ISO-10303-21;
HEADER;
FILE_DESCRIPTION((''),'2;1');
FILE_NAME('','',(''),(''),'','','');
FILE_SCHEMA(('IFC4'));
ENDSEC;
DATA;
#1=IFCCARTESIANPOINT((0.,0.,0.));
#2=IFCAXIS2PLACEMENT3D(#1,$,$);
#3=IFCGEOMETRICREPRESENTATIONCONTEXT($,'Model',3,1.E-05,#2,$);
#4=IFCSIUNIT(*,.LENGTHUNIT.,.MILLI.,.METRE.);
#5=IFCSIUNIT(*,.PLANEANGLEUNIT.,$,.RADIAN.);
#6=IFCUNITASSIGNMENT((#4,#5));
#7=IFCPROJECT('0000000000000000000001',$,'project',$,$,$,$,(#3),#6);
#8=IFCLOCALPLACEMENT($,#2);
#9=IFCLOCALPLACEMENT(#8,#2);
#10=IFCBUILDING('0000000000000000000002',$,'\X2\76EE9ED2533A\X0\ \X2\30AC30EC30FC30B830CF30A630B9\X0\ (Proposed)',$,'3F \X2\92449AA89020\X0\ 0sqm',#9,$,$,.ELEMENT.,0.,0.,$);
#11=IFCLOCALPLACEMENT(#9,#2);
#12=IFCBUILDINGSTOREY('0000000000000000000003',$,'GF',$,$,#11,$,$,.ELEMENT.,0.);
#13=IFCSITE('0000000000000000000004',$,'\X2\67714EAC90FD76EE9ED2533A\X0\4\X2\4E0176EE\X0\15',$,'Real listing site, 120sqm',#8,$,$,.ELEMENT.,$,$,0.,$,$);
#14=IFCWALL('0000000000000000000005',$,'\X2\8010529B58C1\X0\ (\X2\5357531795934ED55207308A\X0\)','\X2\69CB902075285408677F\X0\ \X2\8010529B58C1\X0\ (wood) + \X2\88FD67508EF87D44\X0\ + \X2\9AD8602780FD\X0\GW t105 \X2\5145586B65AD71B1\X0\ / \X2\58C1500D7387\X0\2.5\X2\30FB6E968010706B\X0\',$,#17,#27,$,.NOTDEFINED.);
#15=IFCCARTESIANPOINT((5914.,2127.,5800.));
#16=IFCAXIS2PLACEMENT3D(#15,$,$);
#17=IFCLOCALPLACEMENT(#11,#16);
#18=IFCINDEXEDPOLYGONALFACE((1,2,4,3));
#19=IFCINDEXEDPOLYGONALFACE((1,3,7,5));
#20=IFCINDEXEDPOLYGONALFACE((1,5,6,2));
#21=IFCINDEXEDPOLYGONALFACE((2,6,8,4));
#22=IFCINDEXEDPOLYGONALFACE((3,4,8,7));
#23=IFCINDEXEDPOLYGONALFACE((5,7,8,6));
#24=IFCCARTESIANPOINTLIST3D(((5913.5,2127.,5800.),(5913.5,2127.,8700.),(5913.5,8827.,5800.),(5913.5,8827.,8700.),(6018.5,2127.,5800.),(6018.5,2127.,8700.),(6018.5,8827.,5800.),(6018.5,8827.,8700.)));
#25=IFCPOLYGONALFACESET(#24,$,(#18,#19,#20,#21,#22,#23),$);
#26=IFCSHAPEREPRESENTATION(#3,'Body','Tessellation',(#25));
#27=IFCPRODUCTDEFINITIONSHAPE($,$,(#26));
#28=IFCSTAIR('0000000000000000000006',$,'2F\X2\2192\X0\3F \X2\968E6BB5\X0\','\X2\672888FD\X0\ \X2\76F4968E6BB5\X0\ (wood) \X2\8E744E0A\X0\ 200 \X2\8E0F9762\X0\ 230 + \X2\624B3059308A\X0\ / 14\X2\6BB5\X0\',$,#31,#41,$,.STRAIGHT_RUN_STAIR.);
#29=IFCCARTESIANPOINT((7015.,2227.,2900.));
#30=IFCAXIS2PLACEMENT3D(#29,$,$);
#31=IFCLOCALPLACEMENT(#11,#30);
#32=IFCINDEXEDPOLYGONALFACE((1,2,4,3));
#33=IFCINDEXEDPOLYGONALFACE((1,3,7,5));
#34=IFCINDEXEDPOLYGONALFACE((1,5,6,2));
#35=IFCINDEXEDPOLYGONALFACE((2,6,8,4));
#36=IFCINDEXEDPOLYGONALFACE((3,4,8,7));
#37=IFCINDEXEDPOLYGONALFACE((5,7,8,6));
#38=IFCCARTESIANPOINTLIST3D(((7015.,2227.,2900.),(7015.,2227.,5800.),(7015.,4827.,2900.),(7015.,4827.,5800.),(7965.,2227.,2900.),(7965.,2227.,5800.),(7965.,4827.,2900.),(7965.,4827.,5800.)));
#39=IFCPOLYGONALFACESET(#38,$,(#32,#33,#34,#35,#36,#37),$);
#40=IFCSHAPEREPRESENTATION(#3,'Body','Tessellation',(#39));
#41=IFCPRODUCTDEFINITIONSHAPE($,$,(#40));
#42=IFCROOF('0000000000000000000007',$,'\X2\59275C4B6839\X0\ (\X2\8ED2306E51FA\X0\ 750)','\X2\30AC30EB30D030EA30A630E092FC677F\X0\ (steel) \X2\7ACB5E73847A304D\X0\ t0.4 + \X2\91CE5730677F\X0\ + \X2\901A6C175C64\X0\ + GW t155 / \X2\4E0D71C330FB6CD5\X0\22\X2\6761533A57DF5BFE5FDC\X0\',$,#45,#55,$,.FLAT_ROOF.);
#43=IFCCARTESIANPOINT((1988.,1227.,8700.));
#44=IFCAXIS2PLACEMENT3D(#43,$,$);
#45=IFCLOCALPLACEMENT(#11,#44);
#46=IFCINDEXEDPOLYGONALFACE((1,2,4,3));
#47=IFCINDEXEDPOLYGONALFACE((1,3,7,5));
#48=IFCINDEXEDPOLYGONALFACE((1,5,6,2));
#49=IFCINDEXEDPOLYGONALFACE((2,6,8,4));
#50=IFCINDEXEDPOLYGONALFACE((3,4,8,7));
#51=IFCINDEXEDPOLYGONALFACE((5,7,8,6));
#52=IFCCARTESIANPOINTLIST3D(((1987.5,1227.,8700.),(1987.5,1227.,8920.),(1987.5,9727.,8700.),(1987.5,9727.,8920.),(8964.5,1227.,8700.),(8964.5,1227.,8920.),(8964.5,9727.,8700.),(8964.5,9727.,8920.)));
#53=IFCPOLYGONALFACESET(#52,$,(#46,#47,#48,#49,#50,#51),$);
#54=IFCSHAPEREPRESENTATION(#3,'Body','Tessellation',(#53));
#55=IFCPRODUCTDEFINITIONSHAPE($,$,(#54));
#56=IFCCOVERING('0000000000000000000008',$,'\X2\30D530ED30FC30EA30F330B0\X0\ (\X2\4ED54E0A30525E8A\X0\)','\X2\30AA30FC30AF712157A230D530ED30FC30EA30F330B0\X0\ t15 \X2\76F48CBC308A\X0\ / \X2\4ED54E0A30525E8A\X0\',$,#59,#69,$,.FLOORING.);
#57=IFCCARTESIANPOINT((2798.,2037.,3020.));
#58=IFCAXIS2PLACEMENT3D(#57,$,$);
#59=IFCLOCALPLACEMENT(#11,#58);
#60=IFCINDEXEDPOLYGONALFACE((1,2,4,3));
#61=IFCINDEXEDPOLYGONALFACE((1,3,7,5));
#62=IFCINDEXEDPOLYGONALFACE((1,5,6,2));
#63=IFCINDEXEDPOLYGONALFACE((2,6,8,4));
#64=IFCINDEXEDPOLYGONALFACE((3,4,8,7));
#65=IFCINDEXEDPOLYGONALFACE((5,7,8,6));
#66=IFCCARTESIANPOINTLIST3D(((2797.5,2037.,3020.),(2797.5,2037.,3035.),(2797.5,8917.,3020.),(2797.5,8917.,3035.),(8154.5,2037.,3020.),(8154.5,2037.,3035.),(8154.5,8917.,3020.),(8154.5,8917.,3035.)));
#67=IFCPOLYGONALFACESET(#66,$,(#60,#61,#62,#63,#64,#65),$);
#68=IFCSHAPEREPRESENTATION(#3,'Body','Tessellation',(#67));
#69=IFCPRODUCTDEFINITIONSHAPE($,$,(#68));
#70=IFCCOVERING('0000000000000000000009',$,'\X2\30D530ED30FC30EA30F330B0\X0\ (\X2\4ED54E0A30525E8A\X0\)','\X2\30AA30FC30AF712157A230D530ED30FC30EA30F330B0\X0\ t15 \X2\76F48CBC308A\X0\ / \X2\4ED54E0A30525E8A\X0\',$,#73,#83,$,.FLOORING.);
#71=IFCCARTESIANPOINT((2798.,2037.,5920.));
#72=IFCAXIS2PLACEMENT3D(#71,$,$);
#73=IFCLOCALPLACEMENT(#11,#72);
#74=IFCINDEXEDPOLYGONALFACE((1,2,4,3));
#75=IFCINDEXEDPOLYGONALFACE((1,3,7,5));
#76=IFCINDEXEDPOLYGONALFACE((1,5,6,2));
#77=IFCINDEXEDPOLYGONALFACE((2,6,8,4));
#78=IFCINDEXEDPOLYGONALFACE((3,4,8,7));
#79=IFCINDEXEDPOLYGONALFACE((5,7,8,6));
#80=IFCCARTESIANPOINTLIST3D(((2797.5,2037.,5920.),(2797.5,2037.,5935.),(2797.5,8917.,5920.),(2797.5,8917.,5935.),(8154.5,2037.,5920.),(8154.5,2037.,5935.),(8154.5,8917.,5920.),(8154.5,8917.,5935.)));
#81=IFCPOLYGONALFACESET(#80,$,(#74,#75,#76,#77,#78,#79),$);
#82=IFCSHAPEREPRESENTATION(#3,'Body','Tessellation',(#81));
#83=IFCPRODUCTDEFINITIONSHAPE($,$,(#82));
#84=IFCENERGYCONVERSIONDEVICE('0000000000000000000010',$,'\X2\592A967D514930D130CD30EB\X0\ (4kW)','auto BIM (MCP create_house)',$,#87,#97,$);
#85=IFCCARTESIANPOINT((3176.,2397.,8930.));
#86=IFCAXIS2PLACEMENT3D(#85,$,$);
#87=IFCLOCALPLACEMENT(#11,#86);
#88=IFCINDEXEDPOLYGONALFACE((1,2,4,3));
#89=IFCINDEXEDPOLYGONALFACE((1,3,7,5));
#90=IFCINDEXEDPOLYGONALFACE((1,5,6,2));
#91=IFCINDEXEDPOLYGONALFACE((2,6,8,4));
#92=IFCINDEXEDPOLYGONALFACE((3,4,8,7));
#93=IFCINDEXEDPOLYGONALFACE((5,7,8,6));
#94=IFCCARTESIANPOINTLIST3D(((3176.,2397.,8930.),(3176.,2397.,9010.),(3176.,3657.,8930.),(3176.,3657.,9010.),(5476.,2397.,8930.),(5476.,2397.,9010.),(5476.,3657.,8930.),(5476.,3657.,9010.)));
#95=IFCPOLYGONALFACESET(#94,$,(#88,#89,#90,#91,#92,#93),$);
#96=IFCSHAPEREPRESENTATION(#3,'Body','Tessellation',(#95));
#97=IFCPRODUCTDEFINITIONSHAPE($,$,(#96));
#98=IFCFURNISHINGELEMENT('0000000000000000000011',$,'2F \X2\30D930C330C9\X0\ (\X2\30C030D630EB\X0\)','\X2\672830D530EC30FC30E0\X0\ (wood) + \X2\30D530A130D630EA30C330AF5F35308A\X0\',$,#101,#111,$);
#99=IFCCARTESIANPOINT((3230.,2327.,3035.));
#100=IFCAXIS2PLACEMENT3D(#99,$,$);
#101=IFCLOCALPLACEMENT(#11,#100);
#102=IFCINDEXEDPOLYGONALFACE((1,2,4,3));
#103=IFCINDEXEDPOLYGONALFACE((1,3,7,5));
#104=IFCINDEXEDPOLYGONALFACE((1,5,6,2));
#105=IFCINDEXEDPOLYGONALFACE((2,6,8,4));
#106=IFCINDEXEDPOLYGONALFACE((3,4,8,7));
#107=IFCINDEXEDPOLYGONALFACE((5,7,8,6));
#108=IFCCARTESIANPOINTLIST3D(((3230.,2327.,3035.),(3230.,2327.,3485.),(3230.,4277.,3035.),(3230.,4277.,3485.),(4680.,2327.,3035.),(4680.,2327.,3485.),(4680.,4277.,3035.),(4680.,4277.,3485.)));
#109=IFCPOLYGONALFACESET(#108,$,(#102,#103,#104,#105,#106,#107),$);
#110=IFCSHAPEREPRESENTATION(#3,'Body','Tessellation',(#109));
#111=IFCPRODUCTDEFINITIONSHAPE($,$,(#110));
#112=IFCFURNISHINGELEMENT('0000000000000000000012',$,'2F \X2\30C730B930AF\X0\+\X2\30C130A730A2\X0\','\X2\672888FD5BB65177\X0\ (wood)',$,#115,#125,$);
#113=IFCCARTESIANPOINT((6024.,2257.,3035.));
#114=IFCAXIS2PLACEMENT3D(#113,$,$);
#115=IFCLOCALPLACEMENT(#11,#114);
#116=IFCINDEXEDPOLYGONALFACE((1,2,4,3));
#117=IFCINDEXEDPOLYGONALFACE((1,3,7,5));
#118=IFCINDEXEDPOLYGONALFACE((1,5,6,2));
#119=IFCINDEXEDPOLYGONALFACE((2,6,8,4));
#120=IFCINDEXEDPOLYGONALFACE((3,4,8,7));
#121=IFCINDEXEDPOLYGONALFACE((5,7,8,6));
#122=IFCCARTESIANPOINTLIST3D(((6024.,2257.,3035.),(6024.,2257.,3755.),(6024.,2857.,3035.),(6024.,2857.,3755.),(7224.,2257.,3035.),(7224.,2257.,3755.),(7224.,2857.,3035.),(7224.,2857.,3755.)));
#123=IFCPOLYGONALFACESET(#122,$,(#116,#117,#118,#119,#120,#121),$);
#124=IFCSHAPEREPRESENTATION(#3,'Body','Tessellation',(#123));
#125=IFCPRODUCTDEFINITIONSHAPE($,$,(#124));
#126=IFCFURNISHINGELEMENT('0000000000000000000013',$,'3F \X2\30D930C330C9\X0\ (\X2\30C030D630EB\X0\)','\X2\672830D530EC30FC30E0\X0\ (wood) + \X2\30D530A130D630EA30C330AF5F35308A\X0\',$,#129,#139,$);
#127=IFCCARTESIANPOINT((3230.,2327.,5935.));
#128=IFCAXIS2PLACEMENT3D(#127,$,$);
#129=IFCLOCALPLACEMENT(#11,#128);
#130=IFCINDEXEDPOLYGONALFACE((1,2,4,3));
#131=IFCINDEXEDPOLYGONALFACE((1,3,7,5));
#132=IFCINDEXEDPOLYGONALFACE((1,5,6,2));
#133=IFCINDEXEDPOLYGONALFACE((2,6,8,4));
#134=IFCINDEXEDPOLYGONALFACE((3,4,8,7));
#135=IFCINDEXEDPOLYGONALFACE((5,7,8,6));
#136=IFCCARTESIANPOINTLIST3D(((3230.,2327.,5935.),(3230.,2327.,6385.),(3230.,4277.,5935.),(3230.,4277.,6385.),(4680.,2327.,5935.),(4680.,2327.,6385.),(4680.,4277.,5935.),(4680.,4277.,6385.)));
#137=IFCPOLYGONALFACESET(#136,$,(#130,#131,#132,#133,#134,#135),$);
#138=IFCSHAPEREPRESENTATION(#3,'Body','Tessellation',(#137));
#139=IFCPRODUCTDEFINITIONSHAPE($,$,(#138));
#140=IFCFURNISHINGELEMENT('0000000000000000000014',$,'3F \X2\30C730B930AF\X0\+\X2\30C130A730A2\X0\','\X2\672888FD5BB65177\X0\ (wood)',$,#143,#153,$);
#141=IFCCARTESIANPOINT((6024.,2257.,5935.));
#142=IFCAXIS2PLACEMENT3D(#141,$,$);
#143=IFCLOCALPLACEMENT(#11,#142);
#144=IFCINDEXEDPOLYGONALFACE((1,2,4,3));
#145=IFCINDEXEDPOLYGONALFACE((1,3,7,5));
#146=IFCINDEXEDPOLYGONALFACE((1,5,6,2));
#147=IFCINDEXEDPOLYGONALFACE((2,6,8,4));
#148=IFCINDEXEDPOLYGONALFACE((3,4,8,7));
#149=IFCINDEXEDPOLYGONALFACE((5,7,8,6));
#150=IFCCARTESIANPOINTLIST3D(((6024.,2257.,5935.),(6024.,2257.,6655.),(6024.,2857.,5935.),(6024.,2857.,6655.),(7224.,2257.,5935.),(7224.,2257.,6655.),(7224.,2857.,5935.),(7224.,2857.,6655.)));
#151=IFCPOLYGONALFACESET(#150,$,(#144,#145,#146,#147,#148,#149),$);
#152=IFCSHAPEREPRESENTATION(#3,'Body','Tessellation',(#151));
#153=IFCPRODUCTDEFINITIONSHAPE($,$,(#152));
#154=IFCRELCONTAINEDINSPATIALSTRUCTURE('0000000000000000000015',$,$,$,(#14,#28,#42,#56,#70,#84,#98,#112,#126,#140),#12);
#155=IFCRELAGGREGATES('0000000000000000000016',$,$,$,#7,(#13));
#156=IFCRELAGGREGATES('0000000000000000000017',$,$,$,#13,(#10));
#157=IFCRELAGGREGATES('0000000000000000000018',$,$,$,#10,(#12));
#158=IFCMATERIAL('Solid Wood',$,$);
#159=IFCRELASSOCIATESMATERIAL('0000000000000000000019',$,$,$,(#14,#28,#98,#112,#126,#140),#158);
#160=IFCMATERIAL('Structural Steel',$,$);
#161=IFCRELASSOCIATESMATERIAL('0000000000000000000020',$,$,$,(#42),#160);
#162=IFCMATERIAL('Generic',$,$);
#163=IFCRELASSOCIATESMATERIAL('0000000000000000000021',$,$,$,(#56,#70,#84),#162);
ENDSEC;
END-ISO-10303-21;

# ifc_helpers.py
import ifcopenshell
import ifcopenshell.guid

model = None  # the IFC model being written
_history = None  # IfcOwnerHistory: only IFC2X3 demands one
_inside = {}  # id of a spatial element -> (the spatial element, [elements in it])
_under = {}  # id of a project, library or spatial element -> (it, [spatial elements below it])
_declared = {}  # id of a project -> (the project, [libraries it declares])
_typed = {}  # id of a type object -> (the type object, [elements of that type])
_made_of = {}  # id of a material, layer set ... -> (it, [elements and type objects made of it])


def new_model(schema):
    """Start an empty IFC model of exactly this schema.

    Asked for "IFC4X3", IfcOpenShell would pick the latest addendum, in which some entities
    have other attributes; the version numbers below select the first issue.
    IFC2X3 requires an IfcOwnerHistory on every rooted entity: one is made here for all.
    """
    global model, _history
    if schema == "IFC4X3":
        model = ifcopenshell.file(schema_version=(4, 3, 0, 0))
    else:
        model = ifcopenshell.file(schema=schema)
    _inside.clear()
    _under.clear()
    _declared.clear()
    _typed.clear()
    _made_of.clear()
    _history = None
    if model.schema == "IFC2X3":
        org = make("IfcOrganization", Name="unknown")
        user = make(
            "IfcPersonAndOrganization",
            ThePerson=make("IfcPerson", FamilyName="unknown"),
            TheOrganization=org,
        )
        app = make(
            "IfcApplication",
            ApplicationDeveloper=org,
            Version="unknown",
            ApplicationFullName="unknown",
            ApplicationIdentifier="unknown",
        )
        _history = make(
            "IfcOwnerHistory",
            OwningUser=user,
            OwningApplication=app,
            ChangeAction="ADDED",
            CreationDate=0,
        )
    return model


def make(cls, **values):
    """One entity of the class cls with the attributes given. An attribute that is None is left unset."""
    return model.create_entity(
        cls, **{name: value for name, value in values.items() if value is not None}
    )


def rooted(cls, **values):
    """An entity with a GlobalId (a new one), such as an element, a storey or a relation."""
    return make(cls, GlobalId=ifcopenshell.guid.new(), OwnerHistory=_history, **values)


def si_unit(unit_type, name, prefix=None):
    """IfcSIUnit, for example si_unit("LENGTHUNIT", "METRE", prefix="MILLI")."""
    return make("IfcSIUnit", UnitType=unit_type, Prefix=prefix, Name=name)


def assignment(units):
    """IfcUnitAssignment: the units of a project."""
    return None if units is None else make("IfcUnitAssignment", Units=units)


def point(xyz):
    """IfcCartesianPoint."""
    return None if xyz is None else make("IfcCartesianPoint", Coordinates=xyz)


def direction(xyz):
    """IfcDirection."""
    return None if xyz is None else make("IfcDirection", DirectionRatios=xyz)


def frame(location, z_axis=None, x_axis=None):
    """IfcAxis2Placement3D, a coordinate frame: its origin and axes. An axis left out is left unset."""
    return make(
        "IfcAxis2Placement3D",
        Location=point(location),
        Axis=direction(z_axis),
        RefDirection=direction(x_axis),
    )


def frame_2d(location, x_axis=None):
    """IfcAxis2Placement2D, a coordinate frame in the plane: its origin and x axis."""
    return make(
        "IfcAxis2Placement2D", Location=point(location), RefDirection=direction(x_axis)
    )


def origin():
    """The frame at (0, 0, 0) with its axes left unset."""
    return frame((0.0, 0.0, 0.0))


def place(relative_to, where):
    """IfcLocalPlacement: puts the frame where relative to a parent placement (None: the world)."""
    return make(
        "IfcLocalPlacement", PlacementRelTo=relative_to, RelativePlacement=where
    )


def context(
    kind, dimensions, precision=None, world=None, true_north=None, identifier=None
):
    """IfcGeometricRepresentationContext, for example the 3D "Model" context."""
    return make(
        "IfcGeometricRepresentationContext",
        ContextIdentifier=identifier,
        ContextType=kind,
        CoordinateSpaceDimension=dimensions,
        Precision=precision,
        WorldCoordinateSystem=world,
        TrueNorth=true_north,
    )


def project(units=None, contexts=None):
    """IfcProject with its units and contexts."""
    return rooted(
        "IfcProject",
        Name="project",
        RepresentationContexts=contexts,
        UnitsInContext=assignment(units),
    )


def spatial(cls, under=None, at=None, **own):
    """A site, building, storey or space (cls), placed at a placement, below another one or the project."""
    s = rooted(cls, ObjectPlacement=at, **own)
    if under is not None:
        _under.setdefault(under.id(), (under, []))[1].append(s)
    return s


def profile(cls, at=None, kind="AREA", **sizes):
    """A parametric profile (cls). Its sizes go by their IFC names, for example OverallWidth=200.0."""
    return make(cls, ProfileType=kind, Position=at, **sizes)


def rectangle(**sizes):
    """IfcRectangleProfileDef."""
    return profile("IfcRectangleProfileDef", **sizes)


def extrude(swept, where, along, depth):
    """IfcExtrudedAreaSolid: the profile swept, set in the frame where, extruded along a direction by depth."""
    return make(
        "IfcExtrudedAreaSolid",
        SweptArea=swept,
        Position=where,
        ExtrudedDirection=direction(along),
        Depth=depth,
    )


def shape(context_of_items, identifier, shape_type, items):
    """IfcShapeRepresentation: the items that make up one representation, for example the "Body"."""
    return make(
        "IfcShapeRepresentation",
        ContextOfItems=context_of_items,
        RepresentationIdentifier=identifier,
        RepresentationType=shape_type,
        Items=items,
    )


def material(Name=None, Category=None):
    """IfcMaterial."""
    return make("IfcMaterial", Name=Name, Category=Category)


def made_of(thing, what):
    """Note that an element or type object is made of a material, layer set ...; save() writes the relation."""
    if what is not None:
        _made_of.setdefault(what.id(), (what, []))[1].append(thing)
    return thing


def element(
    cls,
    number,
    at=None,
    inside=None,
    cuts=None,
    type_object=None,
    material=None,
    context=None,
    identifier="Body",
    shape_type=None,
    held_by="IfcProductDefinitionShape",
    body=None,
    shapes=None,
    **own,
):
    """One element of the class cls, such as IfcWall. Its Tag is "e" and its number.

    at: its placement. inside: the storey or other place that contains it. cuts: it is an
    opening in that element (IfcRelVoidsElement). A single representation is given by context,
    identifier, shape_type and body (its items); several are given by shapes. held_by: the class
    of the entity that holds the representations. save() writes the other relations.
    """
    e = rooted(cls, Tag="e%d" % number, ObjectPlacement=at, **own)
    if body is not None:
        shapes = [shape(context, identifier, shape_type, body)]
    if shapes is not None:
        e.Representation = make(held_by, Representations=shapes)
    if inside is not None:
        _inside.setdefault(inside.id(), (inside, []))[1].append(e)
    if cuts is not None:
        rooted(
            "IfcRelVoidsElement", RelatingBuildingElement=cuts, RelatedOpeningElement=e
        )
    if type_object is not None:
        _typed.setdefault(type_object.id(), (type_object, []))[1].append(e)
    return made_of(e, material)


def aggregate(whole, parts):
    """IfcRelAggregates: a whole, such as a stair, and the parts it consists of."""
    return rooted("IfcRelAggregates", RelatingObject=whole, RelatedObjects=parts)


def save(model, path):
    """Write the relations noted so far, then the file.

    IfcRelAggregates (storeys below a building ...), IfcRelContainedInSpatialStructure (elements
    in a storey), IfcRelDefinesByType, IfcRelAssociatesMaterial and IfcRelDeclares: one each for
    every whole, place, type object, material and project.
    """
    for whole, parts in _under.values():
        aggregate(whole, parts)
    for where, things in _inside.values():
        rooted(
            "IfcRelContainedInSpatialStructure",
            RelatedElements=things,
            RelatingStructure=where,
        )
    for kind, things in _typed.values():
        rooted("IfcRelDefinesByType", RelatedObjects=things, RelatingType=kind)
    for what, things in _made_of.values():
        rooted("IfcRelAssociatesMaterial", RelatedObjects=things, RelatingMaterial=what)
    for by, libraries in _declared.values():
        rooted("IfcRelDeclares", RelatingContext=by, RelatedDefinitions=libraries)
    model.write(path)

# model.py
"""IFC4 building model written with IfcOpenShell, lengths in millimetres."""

from ifc_helpers import new_model, si_unit, frame, frame_2d, origin, place, context, project, spatial, rectangle, extrude, material, element, save


model = new_model("IFC4")

# Units and contexts
model_context = context("Model", 3, precision=1e-05, world=origin())
ifc_project = project(units=[si_unit("LENGTHUNIT", "METRE", prefix="MILLI"), si_unit("PLANEANGLEUNIT", "RADIAN")], contexts=[model_context])

# Site, building, storey
site_placement = place(None, origin())
site = spatial("IfcSite", under=ifc_project, at=site_placement, Name="東京都目黒区4丁目15", ObjectType="Real listing site, 120sqm", CompositionType="ELEMENT", RefElevation=0.0)
building_placement = place(site_placement, origin())
building = spatial("IfcBuilding", under=site, at=building_placement, Name="目黒区 ガレージハウス (Proposed)", ObjectType="3F 鉄骨造 0sqm", CompositionType="ELEMENT", ElevationOfRefHeight=0.0, ElevationOfTerrain=0.0)
storey_placement = place(building_placement, origin())
storey = spatial("IfcBuildingStorey", under=building, at=storey_placement, Name="GF", CompositionType="ELEMENT", Elevation=0.0)

# Shared definitions
ifc_material_1 = material(Name="Solid Wood")

# Wall
wall_1_placement = place(storey_placement, frame((5914.0, 2127.0, 5800.0)))
element("IfcWall", 1, at=wall_1_placement, inside=storey, material=ifc_material_1, Name="耐力壁 (南北間仕切り)", Description="構造用合板 耐力壁 (wood) + 製材軸組 + 高性能GW t105 充填断熱 / 壁倍率2.5・準耐火", PredefinedType="NOTDEFINED", context=model_context, shape_type="SweptSolid", body=[
    extrude(rectangle(XDim=105.0, YDim=6700.0, at=frame_2d((52.0, 3350.0))), frame((5914.0, 2127.0, 5800.0)), (0.0, 0.0, 1.0), 2900.0),
])

# Stair
stair_placement = place(storey_placement, frame((7015.0, 2227.0, 2900.0)))
element("IfcStair", 2, at=stair_placement, inside=storey, material=ifc_material_1, Name="2F→3F 階段", Description="木製 直階段 (wood) 蹴上 200 踏面 230 + 手すり / 14段", PredefinedType="STRAIGHT_RUN_STAIR", context=model_context, shape_type="SweptSolid", body=[
    extrude(rectangle(XDim=950.0, YDim=2600.0, at=frame_2d((475.0, 1300.0))), frame((7015.0, 2227.0, 2900.0)), (0.0, 0.0, 1.0), 2900.0),
])

# Roof
ifc_material_2 = material(Name="Structural Steel")
roof_placement = place(storey_placement, frame((1988.0, 1227.0, 8700.0)))
element("IfcRoof", 3, at=roof_placement, inside=storey, material=ifc_material_2, Name="大屋根 (軒の出 750)", Description="ガルバリウム鋼板 (steel) 立平葺き t0.4 + 野地板 + 通気層 + GW t155 / 不燃・法22条区域対応", PredefinedType="FLAT_ROOF", context=model_context, shape_type="SweptSolid", body=[
    extrude(rectangle(XDim=6977.0, YDim=8500.0, at=frame_2d((3488.0, 4250.0))), frame((1988.0, 1227.0, 8700.0)), (0.0, 0.0, 1.0), 220.0),
])

# Coverings
ifc_material_3 = material(Name="Generic")
covering_1_placement = place(storey_placement, frame((2798.0, 2037.0, 3020.0)))
element("IfcCovering", 4, at=covering_1_placement, inside=storey, material=ifc_material_3, Name="フローリング (仕上げ床)", Description="オーク無垢フローリング t15 直貼り / 仕上げ床", PredefinedType="FLOORING", context=model_context, shape_type="SweptSolid", body=[
    extrude(rectangle(XDim=5357.0, YDim=6880.0, at=frame_2d((2678.0, 3440.0))), frame((2798.0, 2037.0, 3020.0)), (0.0, 0.0, 1.0), 15.0),
])
covering_2_placement = place(storey_placement, frame((2798.0, 2037.0, 5920.0)))
element("IfcCovering", 5, at=covering_2_placement, inside=storey, material=ifc_material_3, Name="フローリング (仕上げ床)", Description="オーク無垢フローリング t15 直貼り / 仕上げ床", PredefinedType="FLOORING", context=model_context, shape_type="SweptSolid", body=[
    extrude(rectangle(XDim=5357.0, YDim=6880.0, at=frame_2d((2678.0, 3440.0))), frame((2798.0, 2037.0, 5920.0)), (0.0, 0.0, 1.0), 15.0),
])

# Energy conversion device
energy_conversion_device_placement = place(storey_placement, frame((3176.0, 2397.0, 8930.0)))
element("IfcEnergyConversionDevice", 6, at=energy_conversion_device_placement, inside=storey, material=ifc_material_3, Name="太陽光パネル (4kW)", Description="auto BIM (MCP create_house)", context=model_context, shape_type="SweptSolid", body=[
    extrude(rectangle(XDim=2300.0, YDim=1260.0, at=frame_2d((1150.0, 630.0))), frame((3176.0, 2397.0, 8930.0)), (0.0, 0.0, 1.0), 80.0),
])

# Furnishing elements
furnishing_1_placement = place(storey_placement, frame((3230.0, 2327.0, 3035.0)))
element("IfcFurnishingElement", 7, at=furnishing_1_placement, inside=storey, material=ifc_material_1, Name="2F ベッド (ダブル)", Description="木フレーム (wood) + ファブリック張り", context=model_context, shape_type="SweptSolid", body=[
    extrude(rectangle(XDim=1450.0, YDim=1950.0, at=frame_2d((725.0, 975.0))), frame((3230.0, 2327.0, 3035.0)), (0.0, 0.0, 1.0), 450.0),
])
furnishing_2_placement = place(storey_placement, frame((6024.0, 2257.0, 3035.0)))
element("IfcFurnishingElement", 8, at=furnishing_2_placement, inside=storey, material=ifc_material_1, Name="2F デスク+チェア", Description="木製家具 (wood)", context=model_context, shape_type="SweptSolid", body=[
    extrude(rectangle(XDim=1200.0, YDim=600.0, at=frame_2d((600.0, 300.0))), frame((6024.0, 2257.0, 3035.0)), (0.0, 0.0, 1.0), 720.0),
])
furnishing_3_placement = place(storey_placement, frame((3230.0, 2327.0, 5935.0)))
element("IfcFurnishingElement", 9, at=furnishing_3_placement, inside=storey, material=ifc_material_1, Name="3F ベッド (ダブル)", Description="木フレーム (wood) + ファブリック張り", context=model_context, shape_type="SweptSolid", body=[
    extrude(rectangle(XDim=1450.0, YDim=1950.0, at=frame_2d((725.0, 975.0))), frame((3230.0, 2327.0, 5935.0)), (0.0, 0.0, 1.0), 450.0),
])
furnishing_4_placement = place(storey_placement, frame((6024.0, 2257.0, 5935.0)))
element("IfcFurnishingElement", 10, at=furnishing_4_placement, inside=storey, material=ifc_material_1, Name="3F デスク+チェア", Description="木製家具 (wood)", context=model_context, shape_type="SweptSolid", body=[
    extrude(rectangle(XDim=1200.0, YDim=600.0, at=frame_2d((600.0, 300.0))), frame((6024.0, 2257.0, 5935.0)), (0.0, 0.0, 1.0), 720.0),
])

save(model, "model.ifc")
